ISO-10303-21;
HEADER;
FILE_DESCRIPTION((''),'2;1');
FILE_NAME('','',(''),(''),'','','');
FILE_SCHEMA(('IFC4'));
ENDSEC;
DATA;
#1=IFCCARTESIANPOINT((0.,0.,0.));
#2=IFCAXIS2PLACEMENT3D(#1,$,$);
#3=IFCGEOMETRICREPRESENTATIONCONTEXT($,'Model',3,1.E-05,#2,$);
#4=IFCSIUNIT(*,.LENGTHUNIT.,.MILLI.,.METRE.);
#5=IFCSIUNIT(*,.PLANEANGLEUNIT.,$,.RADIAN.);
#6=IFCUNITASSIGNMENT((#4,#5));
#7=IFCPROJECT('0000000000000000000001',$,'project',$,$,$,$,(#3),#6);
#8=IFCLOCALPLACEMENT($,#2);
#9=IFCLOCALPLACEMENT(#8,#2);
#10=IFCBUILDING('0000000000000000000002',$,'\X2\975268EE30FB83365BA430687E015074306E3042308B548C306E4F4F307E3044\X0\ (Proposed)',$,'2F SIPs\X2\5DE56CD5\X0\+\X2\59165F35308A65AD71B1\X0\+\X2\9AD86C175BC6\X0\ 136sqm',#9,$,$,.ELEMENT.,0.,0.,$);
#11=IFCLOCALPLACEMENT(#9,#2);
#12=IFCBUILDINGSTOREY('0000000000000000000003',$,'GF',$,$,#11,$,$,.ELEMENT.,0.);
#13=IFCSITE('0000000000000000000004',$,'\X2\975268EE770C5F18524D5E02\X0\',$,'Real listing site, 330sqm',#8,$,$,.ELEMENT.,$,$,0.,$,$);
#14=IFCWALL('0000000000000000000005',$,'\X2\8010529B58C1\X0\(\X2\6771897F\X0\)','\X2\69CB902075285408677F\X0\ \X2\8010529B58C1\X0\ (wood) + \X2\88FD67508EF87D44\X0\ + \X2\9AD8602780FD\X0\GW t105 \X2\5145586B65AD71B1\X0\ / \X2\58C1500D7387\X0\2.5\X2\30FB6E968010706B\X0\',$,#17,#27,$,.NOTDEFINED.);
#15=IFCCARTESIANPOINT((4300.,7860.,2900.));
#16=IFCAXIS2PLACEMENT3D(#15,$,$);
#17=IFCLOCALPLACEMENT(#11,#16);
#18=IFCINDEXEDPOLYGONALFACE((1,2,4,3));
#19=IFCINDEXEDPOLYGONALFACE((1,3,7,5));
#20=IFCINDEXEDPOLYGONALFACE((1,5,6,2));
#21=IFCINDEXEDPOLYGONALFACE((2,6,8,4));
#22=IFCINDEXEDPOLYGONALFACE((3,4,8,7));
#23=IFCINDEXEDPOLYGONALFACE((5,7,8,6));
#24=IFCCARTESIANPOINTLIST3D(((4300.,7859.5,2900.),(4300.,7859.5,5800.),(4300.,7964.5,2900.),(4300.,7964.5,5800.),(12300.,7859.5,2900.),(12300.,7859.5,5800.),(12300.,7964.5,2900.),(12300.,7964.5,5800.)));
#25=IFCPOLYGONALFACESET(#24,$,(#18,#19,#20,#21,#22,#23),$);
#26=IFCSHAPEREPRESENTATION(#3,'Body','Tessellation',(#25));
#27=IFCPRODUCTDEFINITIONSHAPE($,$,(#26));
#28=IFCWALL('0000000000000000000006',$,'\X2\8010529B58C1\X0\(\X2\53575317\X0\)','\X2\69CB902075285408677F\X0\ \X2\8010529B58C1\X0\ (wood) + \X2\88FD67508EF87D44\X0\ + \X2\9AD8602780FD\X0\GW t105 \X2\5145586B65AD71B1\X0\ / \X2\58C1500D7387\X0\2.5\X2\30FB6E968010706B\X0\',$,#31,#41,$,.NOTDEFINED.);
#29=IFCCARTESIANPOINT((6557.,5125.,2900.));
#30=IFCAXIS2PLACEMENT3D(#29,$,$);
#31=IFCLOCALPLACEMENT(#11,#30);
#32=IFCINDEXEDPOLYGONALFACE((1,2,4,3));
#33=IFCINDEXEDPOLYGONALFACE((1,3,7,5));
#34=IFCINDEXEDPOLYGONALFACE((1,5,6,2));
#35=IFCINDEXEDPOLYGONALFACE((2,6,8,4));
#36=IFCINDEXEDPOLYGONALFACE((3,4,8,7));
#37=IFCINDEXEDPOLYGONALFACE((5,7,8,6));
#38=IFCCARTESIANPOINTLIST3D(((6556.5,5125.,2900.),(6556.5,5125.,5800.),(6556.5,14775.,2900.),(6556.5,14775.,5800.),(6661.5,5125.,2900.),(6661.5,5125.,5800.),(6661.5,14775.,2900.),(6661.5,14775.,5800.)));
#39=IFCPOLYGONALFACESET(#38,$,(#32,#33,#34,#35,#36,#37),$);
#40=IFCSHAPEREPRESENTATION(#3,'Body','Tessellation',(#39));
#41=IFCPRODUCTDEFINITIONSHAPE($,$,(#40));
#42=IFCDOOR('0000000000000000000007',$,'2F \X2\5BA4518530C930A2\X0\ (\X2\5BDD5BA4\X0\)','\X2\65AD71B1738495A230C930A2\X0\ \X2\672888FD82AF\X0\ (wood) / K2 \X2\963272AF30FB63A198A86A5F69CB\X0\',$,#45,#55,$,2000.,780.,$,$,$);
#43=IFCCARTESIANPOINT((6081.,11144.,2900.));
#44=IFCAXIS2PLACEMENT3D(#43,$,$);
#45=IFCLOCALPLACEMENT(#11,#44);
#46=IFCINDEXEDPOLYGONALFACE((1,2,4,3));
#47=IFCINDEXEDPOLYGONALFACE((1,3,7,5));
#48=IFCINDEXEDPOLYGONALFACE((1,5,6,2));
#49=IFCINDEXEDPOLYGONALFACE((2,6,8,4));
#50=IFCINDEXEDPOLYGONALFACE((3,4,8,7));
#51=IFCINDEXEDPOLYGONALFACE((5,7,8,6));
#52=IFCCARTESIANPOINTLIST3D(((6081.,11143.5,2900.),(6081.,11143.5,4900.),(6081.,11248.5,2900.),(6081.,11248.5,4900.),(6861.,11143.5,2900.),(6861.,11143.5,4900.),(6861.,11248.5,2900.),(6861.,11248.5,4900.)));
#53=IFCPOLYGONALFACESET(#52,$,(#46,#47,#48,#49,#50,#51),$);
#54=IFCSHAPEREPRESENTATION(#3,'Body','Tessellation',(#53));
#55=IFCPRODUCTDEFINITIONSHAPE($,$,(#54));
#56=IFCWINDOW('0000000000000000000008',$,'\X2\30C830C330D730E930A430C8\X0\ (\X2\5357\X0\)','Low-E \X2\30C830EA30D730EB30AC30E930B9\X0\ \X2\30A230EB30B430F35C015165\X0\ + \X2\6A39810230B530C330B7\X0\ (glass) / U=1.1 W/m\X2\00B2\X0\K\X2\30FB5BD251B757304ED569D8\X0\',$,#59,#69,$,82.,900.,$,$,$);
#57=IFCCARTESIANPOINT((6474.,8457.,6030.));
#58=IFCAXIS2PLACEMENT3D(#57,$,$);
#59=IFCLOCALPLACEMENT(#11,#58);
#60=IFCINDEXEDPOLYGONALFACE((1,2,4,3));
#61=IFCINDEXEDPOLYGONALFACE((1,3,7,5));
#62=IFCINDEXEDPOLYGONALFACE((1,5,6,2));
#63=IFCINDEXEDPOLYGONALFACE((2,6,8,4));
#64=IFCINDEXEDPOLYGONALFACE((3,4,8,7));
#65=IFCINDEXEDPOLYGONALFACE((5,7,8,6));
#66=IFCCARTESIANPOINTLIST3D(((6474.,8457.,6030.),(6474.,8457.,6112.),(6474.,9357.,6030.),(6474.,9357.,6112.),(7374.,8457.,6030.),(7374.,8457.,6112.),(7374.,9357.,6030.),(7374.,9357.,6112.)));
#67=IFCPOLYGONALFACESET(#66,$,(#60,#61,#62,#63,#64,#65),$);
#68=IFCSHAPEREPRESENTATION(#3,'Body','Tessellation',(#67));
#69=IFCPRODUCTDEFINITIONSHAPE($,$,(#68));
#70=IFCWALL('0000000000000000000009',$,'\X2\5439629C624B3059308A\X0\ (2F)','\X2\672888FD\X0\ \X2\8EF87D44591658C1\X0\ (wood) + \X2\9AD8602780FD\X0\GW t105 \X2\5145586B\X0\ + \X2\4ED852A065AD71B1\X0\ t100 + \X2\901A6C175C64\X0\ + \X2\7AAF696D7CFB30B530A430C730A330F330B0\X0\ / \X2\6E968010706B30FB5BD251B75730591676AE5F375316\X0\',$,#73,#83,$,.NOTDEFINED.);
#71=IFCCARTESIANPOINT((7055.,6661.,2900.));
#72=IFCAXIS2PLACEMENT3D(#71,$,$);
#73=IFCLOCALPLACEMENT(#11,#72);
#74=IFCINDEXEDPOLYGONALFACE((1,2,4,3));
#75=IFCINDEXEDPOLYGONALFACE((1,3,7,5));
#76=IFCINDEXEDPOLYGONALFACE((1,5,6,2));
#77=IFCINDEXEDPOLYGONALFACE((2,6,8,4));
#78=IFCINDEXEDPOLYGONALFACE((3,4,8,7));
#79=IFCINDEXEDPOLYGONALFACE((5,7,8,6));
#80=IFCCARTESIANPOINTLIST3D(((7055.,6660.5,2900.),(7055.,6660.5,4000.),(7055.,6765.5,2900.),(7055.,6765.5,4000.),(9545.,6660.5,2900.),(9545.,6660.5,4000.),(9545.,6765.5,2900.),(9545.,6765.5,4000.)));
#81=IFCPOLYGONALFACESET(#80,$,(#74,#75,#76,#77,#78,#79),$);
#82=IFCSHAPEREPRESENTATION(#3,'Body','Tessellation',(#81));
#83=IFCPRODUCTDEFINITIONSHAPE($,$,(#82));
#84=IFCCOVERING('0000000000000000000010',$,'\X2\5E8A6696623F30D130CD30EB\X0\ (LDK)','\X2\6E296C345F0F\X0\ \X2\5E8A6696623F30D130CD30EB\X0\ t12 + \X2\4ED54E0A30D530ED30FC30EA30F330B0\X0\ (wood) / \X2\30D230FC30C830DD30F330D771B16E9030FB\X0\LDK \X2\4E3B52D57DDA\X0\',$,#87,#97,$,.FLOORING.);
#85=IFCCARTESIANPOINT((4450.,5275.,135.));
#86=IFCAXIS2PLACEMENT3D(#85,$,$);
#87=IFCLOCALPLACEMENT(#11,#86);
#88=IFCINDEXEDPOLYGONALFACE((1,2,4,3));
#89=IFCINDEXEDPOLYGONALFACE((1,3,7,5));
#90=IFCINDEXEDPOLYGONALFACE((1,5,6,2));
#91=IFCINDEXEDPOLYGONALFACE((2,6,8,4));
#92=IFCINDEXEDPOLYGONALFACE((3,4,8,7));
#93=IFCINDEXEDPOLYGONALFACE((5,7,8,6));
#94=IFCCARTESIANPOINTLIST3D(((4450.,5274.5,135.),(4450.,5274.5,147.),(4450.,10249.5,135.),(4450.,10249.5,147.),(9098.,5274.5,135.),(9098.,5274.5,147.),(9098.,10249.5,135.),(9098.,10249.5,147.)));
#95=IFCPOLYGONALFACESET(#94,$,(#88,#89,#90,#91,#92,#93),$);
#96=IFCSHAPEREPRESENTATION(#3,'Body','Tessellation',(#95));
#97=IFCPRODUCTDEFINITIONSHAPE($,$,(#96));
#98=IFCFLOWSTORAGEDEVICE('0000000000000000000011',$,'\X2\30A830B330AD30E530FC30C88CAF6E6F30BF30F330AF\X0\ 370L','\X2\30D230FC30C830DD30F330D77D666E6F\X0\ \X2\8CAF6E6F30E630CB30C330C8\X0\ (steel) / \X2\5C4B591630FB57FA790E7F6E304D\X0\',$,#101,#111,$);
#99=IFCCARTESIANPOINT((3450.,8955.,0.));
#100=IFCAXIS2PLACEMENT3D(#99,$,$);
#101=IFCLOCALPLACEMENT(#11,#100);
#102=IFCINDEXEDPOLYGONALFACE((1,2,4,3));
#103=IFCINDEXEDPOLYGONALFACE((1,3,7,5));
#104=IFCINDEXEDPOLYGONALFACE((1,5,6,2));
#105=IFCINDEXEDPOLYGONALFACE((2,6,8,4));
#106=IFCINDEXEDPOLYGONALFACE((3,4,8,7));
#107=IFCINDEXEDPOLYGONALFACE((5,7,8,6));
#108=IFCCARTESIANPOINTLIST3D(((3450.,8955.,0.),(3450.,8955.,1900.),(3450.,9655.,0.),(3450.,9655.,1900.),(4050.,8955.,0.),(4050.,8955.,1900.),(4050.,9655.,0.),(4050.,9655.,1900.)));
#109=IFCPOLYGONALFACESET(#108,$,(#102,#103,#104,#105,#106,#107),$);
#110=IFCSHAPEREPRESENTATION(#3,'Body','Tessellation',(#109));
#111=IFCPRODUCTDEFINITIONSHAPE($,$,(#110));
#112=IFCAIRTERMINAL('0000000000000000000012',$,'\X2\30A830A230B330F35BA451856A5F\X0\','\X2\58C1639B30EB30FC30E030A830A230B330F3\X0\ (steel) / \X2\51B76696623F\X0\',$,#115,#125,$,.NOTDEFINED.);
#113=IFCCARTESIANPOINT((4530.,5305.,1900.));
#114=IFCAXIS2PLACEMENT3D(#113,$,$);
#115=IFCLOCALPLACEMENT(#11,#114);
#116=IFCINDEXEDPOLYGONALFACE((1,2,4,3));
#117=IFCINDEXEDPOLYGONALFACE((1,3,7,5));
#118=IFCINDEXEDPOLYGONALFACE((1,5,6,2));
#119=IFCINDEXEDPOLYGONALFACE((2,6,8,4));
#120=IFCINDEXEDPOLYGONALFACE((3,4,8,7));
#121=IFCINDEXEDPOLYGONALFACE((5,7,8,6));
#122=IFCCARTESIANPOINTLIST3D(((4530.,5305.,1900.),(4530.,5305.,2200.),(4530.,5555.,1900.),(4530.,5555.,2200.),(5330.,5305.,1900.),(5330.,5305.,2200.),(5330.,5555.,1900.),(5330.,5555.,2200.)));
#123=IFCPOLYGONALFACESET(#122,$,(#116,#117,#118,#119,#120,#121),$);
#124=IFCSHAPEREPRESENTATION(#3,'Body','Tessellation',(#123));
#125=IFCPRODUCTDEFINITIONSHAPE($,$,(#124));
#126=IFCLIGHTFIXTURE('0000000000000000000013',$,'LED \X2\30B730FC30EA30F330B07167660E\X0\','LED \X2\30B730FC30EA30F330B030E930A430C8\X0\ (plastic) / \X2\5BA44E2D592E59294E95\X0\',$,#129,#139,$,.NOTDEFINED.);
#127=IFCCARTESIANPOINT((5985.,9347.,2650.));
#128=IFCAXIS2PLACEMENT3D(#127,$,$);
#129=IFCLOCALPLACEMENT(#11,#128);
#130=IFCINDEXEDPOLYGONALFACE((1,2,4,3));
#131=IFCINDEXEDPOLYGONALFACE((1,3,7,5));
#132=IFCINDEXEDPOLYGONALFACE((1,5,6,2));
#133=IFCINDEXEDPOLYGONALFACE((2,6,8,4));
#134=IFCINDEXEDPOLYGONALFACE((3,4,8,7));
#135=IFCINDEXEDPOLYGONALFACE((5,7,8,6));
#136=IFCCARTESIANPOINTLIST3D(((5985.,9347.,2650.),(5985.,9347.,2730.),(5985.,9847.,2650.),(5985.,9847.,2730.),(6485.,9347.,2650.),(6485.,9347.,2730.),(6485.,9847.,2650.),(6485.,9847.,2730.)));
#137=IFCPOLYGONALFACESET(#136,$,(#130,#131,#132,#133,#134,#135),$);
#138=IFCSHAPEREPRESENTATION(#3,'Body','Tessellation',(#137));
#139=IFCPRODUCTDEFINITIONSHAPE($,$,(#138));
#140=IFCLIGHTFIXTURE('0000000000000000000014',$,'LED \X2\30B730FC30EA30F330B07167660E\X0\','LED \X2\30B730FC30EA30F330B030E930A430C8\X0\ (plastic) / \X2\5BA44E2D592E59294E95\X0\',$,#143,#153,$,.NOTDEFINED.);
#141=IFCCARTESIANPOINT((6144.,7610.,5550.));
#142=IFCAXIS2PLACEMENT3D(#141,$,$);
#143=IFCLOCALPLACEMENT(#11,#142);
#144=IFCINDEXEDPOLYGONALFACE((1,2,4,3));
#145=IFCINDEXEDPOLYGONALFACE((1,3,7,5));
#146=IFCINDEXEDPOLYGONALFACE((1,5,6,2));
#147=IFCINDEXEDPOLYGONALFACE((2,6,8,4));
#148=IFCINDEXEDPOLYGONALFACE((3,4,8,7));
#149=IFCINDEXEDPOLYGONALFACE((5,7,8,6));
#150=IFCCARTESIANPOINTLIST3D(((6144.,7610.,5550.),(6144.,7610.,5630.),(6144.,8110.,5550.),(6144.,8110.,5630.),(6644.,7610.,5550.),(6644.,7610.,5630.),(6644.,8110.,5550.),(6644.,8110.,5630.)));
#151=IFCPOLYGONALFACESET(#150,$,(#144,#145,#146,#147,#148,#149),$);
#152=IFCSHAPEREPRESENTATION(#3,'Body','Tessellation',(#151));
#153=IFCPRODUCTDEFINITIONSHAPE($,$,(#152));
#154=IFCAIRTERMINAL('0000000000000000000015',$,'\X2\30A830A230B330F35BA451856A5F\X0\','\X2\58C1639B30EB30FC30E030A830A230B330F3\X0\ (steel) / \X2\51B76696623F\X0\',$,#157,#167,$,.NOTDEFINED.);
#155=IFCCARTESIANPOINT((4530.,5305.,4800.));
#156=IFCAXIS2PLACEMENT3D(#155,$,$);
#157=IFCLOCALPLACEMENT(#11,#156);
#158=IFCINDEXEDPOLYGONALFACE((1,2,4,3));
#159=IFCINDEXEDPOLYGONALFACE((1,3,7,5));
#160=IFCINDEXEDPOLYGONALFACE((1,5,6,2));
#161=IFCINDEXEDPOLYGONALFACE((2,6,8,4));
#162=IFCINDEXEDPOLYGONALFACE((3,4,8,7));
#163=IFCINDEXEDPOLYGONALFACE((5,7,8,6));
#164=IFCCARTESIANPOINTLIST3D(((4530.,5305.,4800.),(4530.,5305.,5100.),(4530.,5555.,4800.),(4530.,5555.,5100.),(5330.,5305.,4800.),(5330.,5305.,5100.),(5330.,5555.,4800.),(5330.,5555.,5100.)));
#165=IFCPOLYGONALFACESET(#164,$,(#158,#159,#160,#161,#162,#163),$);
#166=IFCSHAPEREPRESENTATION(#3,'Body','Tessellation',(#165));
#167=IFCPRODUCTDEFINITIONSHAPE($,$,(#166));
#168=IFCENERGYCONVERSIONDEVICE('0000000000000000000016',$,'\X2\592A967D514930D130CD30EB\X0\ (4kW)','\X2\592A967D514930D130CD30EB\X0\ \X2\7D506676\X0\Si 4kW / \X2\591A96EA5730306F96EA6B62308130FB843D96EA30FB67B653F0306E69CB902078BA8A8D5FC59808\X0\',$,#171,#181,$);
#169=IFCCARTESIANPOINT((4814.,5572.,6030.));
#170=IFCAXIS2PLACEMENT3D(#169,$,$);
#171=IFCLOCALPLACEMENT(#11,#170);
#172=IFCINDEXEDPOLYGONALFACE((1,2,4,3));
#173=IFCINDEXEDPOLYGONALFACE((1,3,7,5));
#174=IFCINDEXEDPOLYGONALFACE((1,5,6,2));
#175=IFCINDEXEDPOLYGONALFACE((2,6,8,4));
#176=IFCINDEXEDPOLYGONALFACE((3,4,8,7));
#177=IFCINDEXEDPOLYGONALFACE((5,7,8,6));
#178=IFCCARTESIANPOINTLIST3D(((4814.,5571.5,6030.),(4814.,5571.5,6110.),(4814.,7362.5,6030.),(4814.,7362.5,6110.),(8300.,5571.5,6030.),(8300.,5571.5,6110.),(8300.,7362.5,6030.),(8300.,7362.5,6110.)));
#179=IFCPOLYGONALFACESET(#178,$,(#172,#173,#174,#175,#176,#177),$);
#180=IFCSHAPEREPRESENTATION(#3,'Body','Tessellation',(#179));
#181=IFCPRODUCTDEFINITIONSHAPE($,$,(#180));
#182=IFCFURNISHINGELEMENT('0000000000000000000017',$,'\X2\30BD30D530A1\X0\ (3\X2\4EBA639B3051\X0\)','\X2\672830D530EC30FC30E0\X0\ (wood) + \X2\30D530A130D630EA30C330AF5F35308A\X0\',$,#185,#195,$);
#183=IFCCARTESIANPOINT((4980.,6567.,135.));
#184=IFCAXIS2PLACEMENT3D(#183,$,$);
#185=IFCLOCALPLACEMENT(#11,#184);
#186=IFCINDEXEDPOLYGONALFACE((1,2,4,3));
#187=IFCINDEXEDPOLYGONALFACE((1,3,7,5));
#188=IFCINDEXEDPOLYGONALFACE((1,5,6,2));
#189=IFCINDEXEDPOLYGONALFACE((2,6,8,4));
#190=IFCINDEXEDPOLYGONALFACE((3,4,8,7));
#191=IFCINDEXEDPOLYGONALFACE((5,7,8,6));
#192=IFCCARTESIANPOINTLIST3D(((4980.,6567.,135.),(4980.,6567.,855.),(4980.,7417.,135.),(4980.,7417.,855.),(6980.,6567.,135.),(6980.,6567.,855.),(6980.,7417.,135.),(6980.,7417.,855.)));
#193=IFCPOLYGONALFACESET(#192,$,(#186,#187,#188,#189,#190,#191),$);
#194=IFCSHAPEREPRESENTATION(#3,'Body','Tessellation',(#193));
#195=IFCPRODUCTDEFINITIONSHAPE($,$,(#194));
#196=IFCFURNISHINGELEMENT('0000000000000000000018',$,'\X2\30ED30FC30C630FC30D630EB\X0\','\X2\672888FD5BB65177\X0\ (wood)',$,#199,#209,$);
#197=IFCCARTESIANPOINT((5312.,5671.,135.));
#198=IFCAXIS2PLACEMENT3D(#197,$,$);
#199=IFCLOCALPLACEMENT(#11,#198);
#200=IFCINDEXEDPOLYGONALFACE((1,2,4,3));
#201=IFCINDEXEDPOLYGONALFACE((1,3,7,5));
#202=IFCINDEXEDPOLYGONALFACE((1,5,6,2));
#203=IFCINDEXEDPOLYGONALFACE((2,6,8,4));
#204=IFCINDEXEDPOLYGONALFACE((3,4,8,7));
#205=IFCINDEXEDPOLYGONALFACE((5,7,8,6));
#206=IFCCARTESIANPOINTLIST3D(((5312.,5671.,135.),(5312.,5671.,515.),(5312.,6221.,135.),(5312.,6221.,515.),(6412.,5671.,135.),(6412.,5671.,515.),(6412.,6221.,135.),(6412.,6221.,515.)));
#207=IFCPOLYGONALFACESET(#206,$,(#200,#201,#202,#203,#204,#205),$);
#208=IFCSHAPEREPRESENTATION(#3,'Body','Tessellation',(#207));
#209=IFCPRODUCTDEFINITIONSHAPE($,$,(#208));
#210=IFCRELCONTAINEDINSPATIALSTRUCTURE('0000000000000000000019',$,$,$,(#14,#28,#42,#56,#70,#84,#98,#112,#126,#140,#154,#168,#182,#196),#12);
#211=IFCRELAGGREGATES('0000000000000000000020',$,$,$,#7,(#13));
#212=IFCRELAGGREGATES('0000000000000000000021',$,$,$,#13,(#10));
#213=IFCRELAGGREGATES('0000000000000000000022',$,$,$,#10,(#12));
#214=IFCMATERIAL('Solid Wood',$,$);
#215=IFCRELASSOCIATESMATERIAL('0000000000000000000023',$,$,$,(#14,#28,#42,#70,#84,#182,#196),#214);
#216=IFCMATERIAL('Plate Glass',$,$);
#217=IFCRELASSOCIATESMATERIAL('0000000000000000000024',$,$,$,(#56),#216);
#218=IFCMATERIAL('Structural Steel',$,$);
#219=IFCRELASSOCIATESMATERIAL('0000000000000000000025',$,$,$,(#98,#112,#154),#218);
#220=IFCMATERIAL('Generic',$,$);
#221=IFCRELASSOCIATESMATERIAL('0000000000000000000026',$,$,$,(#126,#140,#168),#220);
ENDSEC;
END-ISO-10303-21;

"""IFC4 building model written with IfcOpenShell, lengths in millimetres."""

from ifc_helpers import new_model, si_unit, frame, frame_2d, origin, place, context, project, spatial, rectangle, extrude, material, element, fill, save


model = new_model("IFC4")

# Units and contexts
model_context = context("Model", 3, precision=1e-05, world=origin())
ifc_project = project(units=[si_unit("LENGTHUNIT", "METRE", prefix="MILLI"), si_unit("PLANEANGLEUNIT", "RADIAN")], contexts=[model_context])

# Site, building, storey
site_placement = place(None, origin())
site = spatial("IfcSite", under=ifc_project, at=site_placement, Name="青森県弘前市", ObjectType="Real listing site, 330sqm", CompositionType="ELEMENT", RefElevation=0.0)
building_placement = place(site_placement, origin())
building = spatial("IfcBuilding", under=site, at=building_placement, Name="青森・茶室と縁側のある和の住まい (Proposed)", ObjectType="2F SIPs工法+外張り断熱+高気密 136sqm", CompositionType="ELEMENT", ElevationOfRefHeight=0.0, ElevationOfTerrain=0.0)
storey_placement = place(building_placement, origin())
storey = spatial("IfcBuildingStorey", under=building, at=storey_placement, Name="GF", CompositionType="ELEMENT", Elevation=0.0)

# Shared definitions
ifc_material_1 = material(Name="Solid Wood")

# Wall
wall_1_placement = place(storey_placement, frame((4300.0, 7860.0, 2900.0)))
element("IfcWall", 1, at=wall_1_placement, inside=storey, material=ifc_material_1, Name="耐力壁(東西)", Description="構造用合板 耐力壁 (wood) + 製材軸組 + 高性能GW t105 充填断熱 / 壁倍率2.5・準耐火", PredefinedType="NOTDEFINED", context=model_context, shape_type="SweptSolid", body=[
    extrude(rectangle(XDim=8000.0, YDim=105.0, at=frame_2d((4000.0, 52.0))), frame((4300.0, 7860.0, 2900.0)), (0.0, 0.0, 1.0), 2900.0),
])

# Wall, opening, door
wall_2_placement = place(storey_placement, frame((6557.0, 5125.0, 2900.0)))
wall_2 = element("IfcWall", 2, at=wall_2_placement, inside=storey, material=ifc_material_1, Name="耐力壁(南北)", Description="構造用合板 耐力壁 (wood) + 製材軸組 + 高性能GW t105 充填断熱 / 壁倍率2.5・準耐火", PredefinedType="NOTDEFINED", context=model_context, shape_type="SweptSolid", body=[
    extrude(rectangle(XDim=105.0, YDim=9650.0, at=frame_2d((52.0, 4825.0))), frame((6557.0, 5125.0, 2900.0)), (0.0, 0.0, 1.0), 2900.0),
])
opening_placement = place(storey_placement, frame((6081.0, 11144.0, 2900.0)))
opening = element("IfcOpeningElement", 3, at=opening_placement, cuts=wall_2, PredefinedType="NOTDEFINED", context=model_context, shape_type="SweptSolid", body=[
    extrude(rectangle(XDim=780.0, YDim=105.0, at=frame_2d((390.0, 52.0))), frame((6081.0, 11144.0, 2900.0)), (0.0, 0.0, 1.0), 2000.0),
])
door_placement = place(storey_placement, frame((6081.0, 11144.0, 2900.0)))
door = element("IfcDoor", 4, at=door_placement, inside=storey, material=ifc_material_1, Name="2F 室内ドア (寝室)", Description="断熱玄関ドア 木製芯 (wood) / K2 防犯・採風機構", OverallHeight=2000.0, OverallWidth=780.0, context=model_context, shape_type="SweptSolid", body=[
    extrude(rectangle(XDim=780.0, YDim=105.0, at=frame_2d((390.0, 52.0))), frame((6081.0, 11144.0, 2900.0)), (0.0, 0.0, 1.0), 2000.0),
])
fill(opening, door)

# Window
ifc_material_2 = material(Name="Plate Glass")
window_placement = place(storey_placement, frame((6474.0, 8457.0, 6030.0)))
element("IfcWindow", 5, at=window_placement, inside=storey, material=ifc_material_2, Name="トップライト (南)", Description="Low-E トリプルガラス アルゴン封入 + 樹脂サッシ (glass) / U=1.1 W/m²K・寒冷地仕様", OverallHeight=82.0, OverallWidth=900.0, context=model_context, shape_type="SweptSolid", body=[
    extrude(rectangle(XDim=900.0, YDim=900.0, at=frame_2d((450.0, 450.0))), frame((6474.0, 8457.0, 6030.0)), (0.0, 0.0, 1.0), 82.0),
])

# Wall
wall_3_placement = place(storey_placement, frame((7055.0, 6661.0, 2900.0)))
element("IfcWall", 6, at=wall_3_placement, inside=storey, material=ifc_material_1, Name="吹抜手すり (2F)", Description="木製 軸組外壁 (wood) + 高性能GW t105 充填 + 付加断熱 t100 + 通気層 + 窯業系サイディング / 準耐火・寒冷地外皮強化", PredefinedType="NOTDEFINED", context=model_context, shape_type="SweptSolid", body=[
    extrude(rectangle(XDim=2490.0, YDim=105.0, at=frame_2d((1245.0, 52.0))), frame((7055.0, 6661.0, 2900.0)), (0.0, 0.0, 1.0), 1100.0),
])

# Covering
covering_placement = place(storey_placement, frame((4450.0, 5275.0, 135.0)))
element("IfcCovering", 7, at=covering_placement, inside=storey, material=ifc_material_1, Name="床暖房パネル (LDK)", Description="温水式 床暖房パネル t12 + 仕上フローリング (wood) / ヒートポンプ熱源・LDK 主動線", PredefinedType="FLOORING", context=model_context, shape_type="SweptSolid", body=[
    extrude(rectangle(XDim=4648.0, YDim=4975.0, at=frame_2d((2324.0, 2487.0))), frame((4450.0, 5275.0, 135.0)), (0.0, 0.0, 1.0), 12.0),
])

# Flow storage device
ifc_material_3 = material(Name="Structural Steel")
flow_storage_device_placement = place(storey_placement, frame((3450.0, 8955.0, 0.0)))
element("IfcFlowStorageDevice", 8, at=flow_storage_device_placement, inside=storey, material=ifc_material_3, Name="エコキュート貯湯タンク 370L", Description="ヒートポンプ給湯 貯湯ユニット (steel) / 屋外・基礎置き", context=model_context, shape_type="SweptSolid", body=[
    extrude(rectangle(XDim=600.0, YDim=700.0, at=frame_2d((300.0, 350.0))), frame((3450.0, 8955.0, 0.0)), (0.0, 0.0, 1.0), 1900.0),
])

# Air terminal
air_terminal_1_placement = place(storey_placement, frame((4530.0, 5305.0, 1900.0)))
element("IfcAirTerminal", 9, at=air_terminal_1_placement, inside=storey, material=ifc_material_3, Name="エアコン室内機", Description="壁掛ルームエアコン (steel) / 冷暖房", PredefinedType="NOTDEFINED", context=model_context, shape_type="SweptSolid", body=[
    extrude(rectangle(XDim=800.0, YDim=250.0, at=frame_2d((400.0, 125.0))), frame((4530.0, 5305.0, 1900.0)), (0.0, 0.0, 1.0), 300.0),
])

# Light fixtures
ifc_material_4 = material(Name="Generic")
light_fixture_1_placement = place(storey_placement, frame((5985.0, 9347.0, 2650.0)))
element("IfcLightFixture", 10, at=light_fixture_1_placement, inside=storey, material=ifc_material_4, Name="LED シーリング照明", Description="LED シーリングライト (plastic) / 室中央天井", PredefinedType="NOTDEFINED", context=model_context, shape_type="SweptSolid", body=[
    extrude(rectangle(XDim=500.0, YDim=500.0, at=frame_2d((250.0, 250.0))), frame((5985.0, 9347.0, 2650.0)), (0.0, 0.0, 1.0), 80.0),
])
light_fixture_2_placement = place(storey_placement, frame((6144.0, 7610.0, 5550.0)))
element("IfcLightFixture", 11, at=light_fixture_2_placement, inside=storey, material=ifc_material_4, Name="LED シーリング照明", Description="LED シーリングライト (plastic) / 室中央天井", PredefinedType="NOTDEFINED", context=model_context, shape_type="SweptSolid", body=[
    extrude(rectangle(XDim=500.0, YDim=500.0, at=frame_2d((250.0, 250.0))), frame((6144.0, 7610.0, 5550.0)), (0.0, 0.0, 1.0), 80.0),
])

# Air terminal
air_terminal_2_placement = place(storey_placement, frame((4530.0, 5305.0, 4800.0)))
element("IfcAirTerminal", 12, at=air_terminal_2_placement, inside=storey, material=ifc_material_3, Name="エアコン室内機", Description="壁掛ルームエアコン (steel) / 冷暖房", PredefinedType="NOTDEFINED", context=model_context, shape_type="SweptSolid", body=[
    extrude(rectangle(XDim=800.0, YDim=250.0, at=frame_2d((400.0, 125.0))), frame((4530.0, 5305.0, 4800.0)), (0.0, 0.0, 1.0), 300.0),
])

# Energy conversion device
energy_conversion_device_placement = place(storey_placement, frame((4814.0, 5572.0, 6030.0)))
element("IfcEnergyConversionDevice", 13, at=energy_conversion_device_placement, inside=storey, material=ifc_material_4, Name="太陽光パネル (4kW)", Description="太陽光パネル 結晶Si 4kW / 多雪地は雪止め・落雪・架台の構造確認必須", context=model_context, shape_type="SweptSolid", body=[
    extrude(rectangle(XDim=3486.0, YDim=1791.0, at=frame_2d((1743.0, 895.0))), frame((4814.0, 5572.0, 6030.0)), (0.0, 0.0, 1.0), 80.0),
])

# Furnishing elements
furnishing_1_placement = place(storey_placement, frame((4980.0, 6567.0, 135.0)))
element("IfcFurnishingElement", 14, at=furnishing_1_placement, inside=storey, material=ifc_material_1, Name="ソファ (3人掛け)", Description="木フレーム (wood) + ファブリック張り", context=model_context, shape_type="SweptSolid", body=[
    extrude(rectangle(XDim=2000.0, YDim=850.0, at=frame_2d((1000.0, 425.0))), frame((4980.0, 6567.0, 135.0)), (0.0, 0.0, 1.0), 720.0),
])
furnishing_2_placement = place(storey_placement, frame((5312.0, 5671.0, 135.0)))
element("IfcFurnishingElement", 15, at=furnishing_2_placement, inside=storey, material=ifc_material_1, Name="ローテーブル", Description="木製家具 (wood)", context=model_context, shape_type="SweptSolid", body=[
    extrude(rectangle(XDim=1100.0, YDim=550.0, at=frame_2d((550.0, 275.0))), frame((5312.0, 5671.0, 135.0)), (0.0, 0.0, 1.0), 380.0),
])

save(model, "model.ifc")
